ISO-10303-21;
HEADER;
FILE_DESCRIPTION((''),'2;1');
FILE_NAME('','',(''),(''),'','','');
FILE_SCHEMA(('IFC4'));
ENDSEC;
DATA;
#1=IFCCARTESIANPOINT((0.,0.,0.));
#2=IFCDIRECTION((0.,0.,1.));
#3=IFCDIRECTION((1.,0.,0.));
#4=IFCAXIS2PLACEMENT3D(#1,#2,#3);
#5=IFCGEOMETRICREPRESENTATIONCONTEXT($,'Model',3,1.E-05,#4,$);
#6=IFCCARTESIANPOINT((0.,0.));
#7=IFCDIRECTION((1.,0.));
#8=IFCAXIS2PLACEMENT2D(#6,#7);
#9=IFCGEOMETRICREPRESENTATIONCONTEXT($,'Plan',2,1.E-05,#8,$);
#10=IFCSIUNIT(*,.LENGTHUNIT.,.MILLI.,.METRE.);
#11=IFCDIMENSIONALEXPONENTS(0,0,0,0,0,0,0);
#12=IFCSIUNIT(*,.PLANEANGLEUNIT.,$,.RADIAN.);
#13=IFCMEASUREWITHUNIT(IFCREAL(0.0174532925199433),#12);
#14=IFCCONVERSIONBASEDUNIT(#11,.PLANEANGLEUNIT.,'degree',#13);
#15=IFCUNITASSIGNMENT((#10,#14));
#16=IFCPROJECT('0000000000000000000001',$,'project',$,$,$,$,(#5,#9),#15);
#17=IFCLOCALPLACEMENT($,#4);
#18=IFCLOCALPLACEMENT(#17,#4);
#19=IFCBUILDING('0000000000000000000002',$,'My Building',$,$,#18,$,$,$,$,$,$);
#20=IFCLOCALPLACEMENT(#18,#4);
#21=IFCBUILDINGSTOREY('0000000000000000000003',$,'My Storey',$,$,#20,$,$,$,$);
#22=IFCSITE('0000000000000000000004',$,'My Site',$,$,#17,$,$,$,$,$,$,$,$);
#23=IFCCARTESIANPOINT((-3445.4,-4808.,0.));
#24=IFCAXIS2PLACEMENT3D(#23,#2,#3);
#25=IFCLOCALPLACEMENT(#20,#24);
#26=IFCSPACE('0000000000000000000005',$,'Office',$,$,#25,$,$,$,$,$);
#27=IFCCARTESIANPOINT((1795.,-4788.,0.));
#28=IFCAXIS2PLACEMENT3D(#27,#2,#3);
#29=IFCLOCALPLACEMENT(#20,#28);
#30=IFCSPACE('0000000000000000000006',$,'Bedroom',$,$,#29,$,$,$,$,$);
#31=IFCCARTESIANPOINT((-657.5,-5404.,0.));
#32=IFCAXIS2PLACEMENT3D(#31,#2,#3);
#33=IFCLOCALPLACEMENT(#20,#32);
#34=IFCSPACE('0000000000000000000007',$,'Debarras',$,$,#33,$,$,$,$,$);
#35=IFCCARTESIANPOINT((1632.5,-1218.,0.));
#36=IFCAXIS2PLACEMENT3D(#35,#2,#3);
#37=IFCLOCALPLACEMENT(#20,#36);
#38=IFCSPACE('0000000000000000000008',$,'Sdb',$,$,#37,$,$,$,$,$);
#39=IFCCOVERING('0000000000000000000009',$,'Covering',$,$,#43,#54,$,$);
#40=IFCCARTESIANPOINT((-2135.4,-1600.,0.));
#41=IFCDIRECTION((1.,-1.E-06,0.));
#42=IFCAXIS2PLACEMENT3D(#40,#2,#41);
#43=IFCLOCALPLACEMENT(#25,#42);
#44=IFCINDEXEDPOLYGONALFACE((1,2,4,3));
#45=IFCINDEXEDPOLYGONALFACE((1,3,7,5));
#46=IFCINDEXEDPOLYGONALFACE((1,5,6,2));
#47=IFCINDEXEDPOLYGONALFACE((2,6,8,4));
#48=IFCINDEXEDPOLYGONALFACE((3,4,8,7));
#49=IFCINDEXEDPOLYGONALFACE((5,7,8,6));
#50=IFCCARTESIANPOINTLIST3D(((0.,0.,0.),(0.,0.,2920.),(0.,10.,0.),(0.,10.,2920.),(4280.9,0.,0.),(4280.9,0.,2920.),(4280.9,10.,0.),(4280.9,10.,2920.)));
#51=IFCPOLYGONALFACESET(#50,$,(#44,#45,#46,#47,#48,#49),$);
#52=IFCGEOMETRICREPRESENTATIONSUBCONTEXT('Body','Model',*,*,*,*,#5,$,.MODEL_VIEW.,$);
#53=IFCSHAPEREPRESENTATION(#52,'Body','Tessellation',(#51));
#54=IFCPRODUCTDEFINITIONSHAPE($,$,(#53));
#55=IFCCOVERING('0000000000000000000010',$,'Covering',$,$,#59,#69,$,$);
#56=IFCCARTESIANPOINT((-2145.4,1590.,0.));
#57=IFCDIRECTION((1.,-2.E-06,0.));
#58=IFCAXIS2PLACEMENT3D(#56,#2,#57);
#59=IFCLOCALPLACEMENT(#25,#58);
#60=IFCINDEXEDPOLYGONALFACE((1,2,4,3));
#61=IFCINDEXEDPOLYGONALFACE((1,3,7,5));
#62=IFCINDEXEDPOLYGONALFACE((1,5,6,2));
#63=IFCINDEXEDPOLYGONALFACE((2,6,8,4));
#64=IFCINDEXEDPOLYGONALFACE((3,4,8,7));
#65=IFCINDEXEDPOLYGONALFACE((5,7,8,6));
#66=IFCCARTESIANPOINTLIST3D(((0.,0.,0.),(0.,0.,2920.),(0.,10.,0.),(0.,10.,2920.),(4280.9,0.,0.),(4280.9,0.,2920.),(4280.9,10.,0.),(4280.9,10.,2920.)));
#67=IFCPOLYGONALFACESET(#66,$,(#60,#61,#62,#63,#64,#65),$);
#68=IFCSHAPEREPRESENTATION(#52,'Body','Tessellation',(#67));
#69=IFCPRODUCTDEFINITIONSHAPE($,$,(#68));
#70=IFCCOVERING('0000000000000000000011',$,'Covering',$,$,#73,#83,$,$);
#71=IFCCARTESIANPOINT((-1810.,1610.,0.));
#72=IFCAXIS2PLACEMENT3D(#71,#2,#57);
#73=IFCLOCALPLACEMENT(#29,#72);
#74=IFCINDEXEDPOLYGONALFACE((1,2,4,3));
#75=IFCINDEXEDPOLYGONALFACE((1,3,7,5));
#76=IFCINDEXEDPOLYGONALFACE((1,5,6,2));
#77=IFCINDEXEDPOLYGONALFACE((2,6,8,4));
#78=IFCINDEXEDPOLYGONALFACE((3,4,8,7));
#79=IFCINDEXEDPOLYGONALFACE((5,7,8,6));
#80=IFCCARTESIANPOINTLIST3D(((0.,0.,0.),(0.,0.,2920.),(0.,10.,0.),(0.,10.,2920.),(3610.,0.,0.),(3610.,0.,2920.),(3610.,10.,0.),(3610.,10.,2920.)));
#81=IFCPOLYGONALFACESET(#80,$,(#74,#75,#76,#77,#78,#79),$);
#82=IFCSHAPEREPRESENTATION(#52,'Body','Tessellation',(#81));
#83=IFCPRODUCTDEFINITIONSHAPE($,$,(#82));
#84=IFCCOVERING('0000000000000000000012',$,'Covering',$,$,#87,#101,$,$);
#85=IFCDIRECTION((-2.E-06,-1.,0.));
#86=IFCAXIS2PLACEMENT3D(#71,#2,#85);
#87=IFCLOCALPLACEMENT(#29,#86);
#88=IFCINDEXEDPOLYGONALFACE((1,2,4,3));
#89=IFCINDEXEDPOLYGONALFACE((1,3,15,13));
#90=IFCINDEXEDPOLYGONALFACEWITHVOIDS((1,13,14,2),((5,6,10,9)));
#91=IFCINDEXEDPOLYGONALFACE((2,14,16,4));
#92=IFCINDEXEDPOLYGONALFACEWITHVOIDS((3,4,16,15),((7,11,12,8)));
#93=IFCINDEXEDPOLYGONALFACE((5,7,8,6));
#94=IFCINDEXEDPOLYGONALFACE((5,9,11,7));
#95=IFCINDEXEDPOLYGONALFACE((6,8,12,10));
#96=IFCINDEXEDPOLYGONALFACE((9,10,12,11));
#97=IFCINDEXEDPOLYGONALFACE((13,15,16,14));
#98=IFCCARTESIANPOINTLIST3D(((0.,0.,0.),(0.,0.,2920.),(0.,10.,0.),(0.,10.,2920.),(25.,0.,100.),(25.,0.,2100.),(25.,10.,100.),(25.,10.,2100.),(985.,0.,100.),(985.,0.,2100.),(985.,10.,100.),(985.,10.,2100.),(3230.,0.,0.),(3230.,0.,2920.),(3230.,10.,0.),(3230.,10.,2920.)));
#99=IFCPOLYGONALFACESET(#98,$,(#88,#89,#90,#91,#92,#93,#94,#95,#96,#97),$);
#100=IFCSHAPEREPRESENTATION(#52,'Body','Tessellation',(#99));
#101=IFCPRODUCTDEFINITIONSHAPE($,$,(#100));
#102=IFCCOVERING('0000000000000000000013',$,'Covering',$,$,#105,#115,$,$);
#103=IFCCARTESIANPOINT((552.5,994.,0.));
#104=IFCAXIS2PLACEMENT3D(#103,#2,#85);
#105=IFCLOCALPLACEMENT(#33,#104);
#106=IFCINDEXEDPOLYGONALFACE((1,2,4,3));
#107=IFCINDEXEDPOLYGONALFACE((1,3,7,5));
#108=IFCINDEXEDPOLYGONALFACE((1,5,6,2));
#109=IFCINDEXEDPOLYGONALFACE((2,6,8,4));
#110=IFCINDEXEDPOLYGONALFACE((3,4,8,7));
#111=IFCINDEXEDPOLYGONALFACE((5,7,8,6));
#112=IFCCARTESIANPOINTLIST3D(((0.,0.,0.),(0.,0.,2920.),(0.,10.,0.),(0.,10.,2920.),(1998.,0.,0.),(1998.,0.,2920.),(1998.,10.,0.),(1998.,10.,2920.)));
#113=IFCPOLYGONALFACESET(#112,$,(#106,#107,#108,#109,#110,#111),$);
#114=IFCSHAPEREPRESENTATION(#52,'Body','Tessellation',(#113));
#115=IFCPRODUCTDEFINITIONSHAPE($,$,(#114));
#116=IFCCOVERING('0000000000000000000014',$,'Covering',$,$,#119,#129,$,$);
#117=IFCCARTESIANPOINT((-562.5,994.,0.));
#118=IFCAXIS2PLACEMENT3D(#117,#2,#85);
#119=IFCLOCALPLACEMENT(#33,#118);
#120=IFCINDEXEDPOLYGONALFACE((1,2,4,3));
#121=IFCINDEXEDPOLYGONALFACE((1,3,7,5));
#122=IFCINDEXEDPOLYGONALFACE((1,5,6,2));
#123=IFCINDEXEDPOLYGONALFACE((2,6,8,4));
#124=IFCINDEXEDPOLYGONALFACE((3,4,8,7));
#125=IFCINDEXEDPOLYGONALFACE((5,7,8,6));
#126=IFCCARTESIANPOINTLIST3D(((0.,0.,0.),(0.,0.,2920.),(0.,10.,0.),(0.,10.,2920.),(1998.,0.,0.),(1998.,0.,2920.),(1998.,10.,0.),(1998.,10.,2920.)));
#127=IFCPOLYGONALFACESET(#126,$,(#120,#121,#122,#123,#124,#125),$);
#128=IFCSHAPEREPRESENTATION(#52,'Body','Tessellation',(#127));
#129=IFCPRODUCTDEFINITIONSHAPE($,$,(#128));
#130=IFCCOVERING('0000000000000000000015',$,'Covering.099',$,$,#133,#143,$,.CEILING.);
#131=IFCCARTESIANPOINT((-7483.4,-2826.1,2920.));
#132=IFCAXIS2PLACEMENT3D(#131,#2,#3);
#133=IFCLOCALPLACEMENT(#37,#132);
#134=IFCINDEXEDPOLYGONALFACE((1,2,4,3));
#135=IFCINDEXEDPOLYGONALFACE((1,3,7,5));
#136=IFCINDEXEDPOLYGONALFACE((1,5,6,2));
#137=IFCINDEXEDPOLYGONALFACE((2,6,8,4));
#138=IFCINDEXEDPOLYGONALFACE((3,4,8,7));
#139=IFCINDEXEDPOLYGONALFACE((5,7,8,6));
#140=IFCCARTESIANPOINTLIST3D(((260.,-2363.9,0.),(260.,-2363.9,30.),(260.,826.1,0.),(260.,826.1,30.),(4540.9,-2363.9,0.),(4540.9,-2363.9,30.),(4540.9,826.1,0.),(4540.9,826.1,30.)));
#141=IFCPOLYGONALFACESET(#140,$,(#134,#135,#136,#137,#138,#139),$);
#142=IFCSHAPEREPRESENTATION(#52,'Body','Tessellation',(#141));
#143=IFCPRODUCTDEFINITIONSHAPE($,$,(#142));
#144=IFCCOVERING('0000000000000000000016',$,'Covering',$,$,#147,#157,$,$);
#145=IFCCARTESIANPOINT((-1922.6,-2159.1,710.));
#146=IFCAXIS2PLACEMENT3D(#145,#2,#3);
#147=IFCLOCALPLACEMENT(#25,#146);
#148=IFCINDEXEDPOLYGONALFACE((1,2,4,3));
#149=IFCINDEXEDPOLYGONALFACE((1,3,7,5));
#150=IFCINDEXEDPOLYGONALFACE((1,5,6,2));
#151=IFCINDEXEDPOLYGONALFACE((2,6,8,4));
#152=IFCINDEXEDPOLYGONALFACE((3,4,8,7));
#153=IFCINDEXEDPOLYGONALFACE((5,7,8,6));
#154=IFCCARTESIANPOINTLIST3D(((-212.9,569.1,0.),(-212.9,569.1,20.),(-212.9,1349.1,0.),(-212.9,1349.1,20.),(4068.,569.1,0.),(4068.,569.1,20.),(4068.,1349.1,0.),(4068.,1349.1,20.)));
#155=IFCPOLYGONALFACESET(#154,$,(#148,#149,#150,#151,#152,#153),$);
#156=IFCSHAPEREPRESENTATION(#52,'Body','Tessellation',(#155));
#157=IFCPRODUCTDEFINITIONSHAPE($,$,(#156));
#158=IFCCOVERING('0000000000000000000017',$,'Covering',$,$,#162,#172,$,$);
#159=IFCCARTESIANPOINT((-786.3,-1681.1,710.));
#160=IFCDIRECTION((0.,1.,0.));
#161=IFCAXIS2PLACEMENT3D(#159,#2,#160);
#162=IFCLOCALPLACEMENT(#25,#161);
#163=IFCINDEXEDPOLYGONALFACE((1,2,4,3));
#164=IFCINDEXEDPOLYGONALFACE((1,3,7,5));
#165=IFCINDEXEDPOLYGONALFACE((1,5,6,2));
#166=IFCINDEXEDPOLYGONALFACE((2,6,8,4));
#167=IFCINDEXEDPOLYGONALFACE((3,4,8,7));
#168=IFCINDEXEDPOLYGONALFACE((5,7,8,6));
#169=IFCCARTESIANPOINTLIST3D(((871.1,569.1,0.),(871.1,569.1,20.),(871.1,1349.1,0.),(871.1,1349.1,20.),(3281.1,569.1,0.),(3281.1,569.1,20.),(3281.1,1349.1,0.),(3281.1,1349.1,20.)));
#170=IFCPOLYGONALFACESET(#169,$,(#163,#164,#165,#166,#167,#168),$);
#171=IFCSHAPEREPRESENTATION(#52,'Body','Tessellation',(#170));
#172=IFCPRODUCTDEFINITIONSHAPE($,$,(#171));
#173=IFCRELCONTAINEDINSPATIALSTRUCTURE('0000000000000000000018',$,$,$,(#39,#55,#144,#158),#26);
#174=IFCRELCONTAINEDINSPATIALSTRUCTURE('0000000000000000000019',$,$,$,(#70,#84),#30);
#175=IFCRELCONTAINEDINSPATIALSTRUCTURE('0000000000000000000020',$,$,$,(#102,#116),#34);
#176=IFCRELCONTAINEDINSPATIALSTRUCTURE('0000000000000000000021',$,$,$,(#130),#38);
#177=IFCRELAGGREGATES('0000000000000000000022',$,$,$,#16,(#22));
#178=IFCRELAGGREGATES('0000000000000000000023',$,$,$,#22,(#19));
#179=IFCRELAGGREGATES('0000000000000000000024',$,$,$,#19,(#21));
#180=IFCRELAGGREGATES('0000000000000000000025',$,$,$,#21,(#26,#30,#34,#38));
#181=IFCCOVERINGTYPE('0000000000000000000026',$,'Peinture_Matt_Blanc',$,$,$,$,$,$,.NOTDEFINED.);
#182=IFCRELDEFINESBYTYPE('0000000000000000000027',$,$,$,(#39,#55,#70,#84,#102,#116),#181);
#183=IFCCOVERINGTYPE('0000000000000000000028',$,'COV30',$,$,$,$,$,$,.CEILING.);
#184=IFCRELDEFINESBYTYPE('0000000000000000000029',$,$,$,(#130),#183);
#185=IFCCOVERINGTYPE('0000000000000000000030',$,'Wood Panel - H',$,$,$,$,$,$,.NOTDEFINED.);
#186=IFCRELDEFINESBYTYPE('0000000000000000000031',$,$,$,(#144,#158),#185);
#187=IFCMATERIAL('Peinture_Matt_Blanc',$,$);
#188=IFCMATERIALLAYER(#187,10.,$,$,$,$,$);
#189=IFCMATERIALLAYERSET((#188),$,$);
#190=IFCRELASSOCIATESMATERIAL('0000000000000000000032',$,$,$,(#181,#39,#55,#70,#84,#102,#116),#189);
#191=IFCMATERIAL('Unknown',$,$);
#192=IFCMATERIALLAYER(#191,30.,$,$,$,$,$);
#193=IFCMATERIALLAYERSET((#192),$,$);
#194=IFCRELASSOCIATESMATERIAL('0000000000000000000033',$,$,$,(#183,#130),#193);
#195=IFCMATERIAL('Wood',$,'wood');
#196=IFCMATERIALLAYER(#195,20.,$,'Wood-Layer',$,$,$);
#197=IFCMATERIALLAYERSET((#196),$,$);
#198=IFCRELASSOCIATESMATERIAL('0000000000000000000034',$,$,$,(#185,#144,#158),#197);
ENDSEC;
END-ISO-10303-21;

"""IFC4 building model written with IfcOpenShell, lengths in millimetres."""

from ifc_helpers import new_model, entity, si_unit, converted_unit, frame, origin_with_axes, origin_2d_with_axis, place, context, subcontext, project, spatial, line, indexed_curve, outline, extrude, clip, halfspace, source, transform, mapped, material, layer, layer_set, layer_usage, type_object, element, save


model = new_model("IFC4")

# Units and contexts
model_context = context("Model", 3, precision=1e-05, world=origin_with_axes())
plan_context = context("Plan", 2, precision=1e-05, world=origin_2d_with_axis())
body_context_1 = subcontext(model_context, "Body", "Model", "MODEL_VIEW")
ifc_project = project(units=[si_unit("LENGTHUNIT", "METRE", prefix="MILLI"), converted_unit("PLANEANGLEUNIT", "degree", entity("IfcReal", 0.0174532925199433), si_unit("PLANEANGLEUNIT", "RADIAN"), dimensions=[0, 0, 0, 0, 0, 0, 0])], contexts=[model_context, plan_context])

# Site, building, storey
site_placement = place(None, origin_with_axes())
site = spatial("IfcSite", under=ifc_project, at=site_placement, Name="My Site")
building_placement = place(site_placement, origin_with_axes())
building = spatial("IfcBuilding", under=site, at=building_placement, Name="My Building")
storey_placement = place(building_placement, origin_with_axes())
storey = spatial("IfcBuildingStorey", under=building, at=storey_placement, Name="My Storey")

# Shared definitions
shared_shape_1 = source(origin_with_axes(), body_context_1, "Body", "SweptSolid", [
    extrude(outline(indexed_curve([(0.0, 0.0), (960.0, 0.0), (960.0, 2000.0), (0.0, 2000.0)], segments=[line(1, 2, 3, 4, 1)])), frame((0.0, -100.0, 0.0), z_axis=(0.0, -1.0, 0.0), x_axis=(1.0, 0.0, 0.0)), (0.0, 0.0, -1.0), 280.0),
])

# Shared definitions
ifc_material_1 = material(Name="Unknown")

# Shared definitions
space_1_placement = place(storey_placement, frame((-3445.4, -4808.0, 0.0), z_axis=(0.0, 0.0, 1.0), x_axis=(1.0, 0.0, 0.0)))
space_1 = spatial("IfcSpace", under=storey, at=space_1_placement, Name="Office")

# Covering
ifc_material_2 = material(Name="Peinture_Matt_Blanc")
ifc_layer_1 = layer(ifc_material_2, 10.0)
ifc_layer_set_1 = layer_set([ifc_layer_1])
ifc_layer_usage_1 = layer_usage(ifc_layer_set_1, "AXIS2", "POSITIVE", 0.0)
covering_type_1 = type_object("IfcCoveringType", Name="Peinture_Matt_Blanc", PredefinedType="NOTDEFINED", material=ifc_layer_set_1)
covering_1_placement = place(space_1_placement, frame((-2135.4, -1600.0, 0.0), z_axis=(0.0, 0.0, 1.0), x_axis=(1.0, -0.000001, 0.0)))
element("IfcCovering", 1, at=covering_1_placement, inside=space_1, type_object=covering_type_1, material=ifc_layer_usage_1, Name="Covering", context=body_context_1, shape_type="Clipping", body=[
    clip(clip(extrude(outline(indexed_curve([(0.0, 0.0), (0.0, 10.0), (4280.9, 10.0), (4280.9, 0.0), (0.0, 0.0)], self_intersect=False)), origin_with_axes(), (0.0, 0.0, 1.0), 2920.0), halfspace(frame((0.0, 0.0, 2920.0), z_axis=(0.0, 0.0, 1.0), x_axis=(-1.0, 0.0, 0.0)), False)), halfspace(frame((0.0, 0.0, 2920.0), z_axis=(0.0, 0.0, 1.0), x_axis=(-1.0, 0.0, 0.0)), False)),
])

# Covering
ifc_layer_usage_2 = layer_usage(ifc_layer_set_1, "AXIS2", "POSITIVE", 0.0)
covering_2_placement = place(space_1_placement, frame((-2145.4, 1590.0, 0.0), z_axis=(0.0, 0.0, 1.0), x_axis=(1.0, -0.000002, 0.0)))
element("IfcCovering", 2, at=covering_2_placement, inside=space_1, type_object=covering_type_1, material=ifc_layer_usage_2, Name="Covering", context=body_context_1, shape_type="Clipping", body=[
    clip(clip(extrude(outline(indexed_curve([(0.0, 0.0), (0.0, 10.0), (4280.9, 10.0), (4280.9, 0.0), (0.0, 0.0)], self_intersect=False)), origin_with_axes(), (0.0, 0.0, 1.0), 2920.0), halfspace(frame((0.0, 0.0, 2920.0), z_axis=(0.0, 0.0, 1.0), x_axis=(-1.0, 0.0, 0.0)), False)), halfspace(frame((0.0, 0.0, 2920.0), z_axis=(0.0, 0.0, 1.0), x_axis=(-1.0, 0.0, 0.0)), False)),
])

# Shared definitions
space_2_placement = place(storey_placement, frame((1795.0, -4788.0, 0.0), z_axis=(0.0, 0.0, 1.0), x_axis=(1.0, 0.0, 0.0)))
space_2 = spatial("IfcSpace", under=storey, at=space_2_placement, Name="Bedroom")

# Covering
ifc_layer_usage_3 = layer_usage(ifc_layer_set_1, "AXIS2", "POSITIVE", 0.0)
covering_3_placement = place(space_2_placement, frame((-1810.0, 1610.0, 0.0), z_axis=(0.0, 0.0, 1.0), x_axis=(1.0, -0.000002, 0.0)))
element("IfcCovering", 3, at=covering_3_placement, inside=space_2, type_object=covering_type_1, material=ifc_layer_usage_3, Name="Covering", context=body_context_1, shape_type="Clipping", body=[
    clip(clip(extrude(outline(indexed_curve([(0.0, 0.0), (0.0, 10.0), (3610.0, 10.0), (3610.0, 0.0), (0.0, 0.0)], self_intersect=False)), origin_with_axes(), (0.0, 0.0, 1.0), 2920.0), halfspace(frame((0.0, 0.0, 2920.0), z_axis=(0.0, 0.0, 1.0), x_axis=(-1.0, 0.0, 0.0)), False)), halfspace(frame((0.0, 0.0, 2920.0), z_axis=(0.0, 0.0, 1.0), x_axis=(-1.0, 0.0, 0.0)), False)),
])

# Covering, opening
ifc_layer_usage_4 = layer_usage(ifc_layer_set_1, "AXIS2", "POSITIVE", 0.0)
covering_4_placement = place(space_2_placement, frame((-1810.0, 1610.0, 0.0), z_axis=(0.0, 0.0, 1.0), x_axis=(-0.000002, -1.0, 0.0)))
covering_4 = element("IfcCovering", 4, at=covering_4_placement, inside=space_2, type_object=covering_type_1, material=ifc_layer_usage_4, Name="Covering", context=body_context_1, shape_type="Clipping", body=[
    clip(clip(extrude(outline(indexed_curve([(0.0, 0.0), (0.0, 10.0), (3230.0, 10.0), (3230.0, 0.0), (0.0, 0.0)], self_intersect=False)), origin_with_axes(), (0.0, 0.0, 1.0), 2920.0), halfspace(frame((0.0, 0.0, 2920.0), z_axis=(0.0, 0.0, 1.0), x_axis=(-1.0, 0.0, 0.0)), False)), halfspace(frame((0.0, 0.0, 2920.0), z_axis=(0.0, 0.0, 1.0), x_axis=(-1.0, 0.0, 0.0)), False)),
])
opening_1_placement = place(covering_4_placement, frame((25.0, -82.5, 100.0), z_axis=(0.0, 0.0, 1.0), x_axis=(1.0, 0.000002, 0.0)))
element("IfcOpeningElement", 5, at=opening_1_placement, cuts=covering_4, PredefinedType="OPENING", context=body_context_1, shape_type="MappedRepresentation", body=[
    mapped(shared_shape_1, transform((0.0, 0.0, 0.0), x_axis=(1.0, 0.0, 0.0), y_axis=(0.0, 1.0, 0.0), z_axis=(0.0, 0.0, 1.0), scale=1.0)),
])

# Shared definitions
space_3_placement = place(storey_placement, frame((-657.5, -5404.0, 0.0), z_axis=(0.0, 0.0, 1.0), x_axis=(1.0, 0.0, 0.0)))
space_3 = spatial("IfcSpace", under=storey, at=space_3_placement, Name="Debarras")

# Coverings
ifc_layer_usage_5 = layer_usage(ifc_layer_set_1, "AXIS2", "POSITIVE", 0.0)
covering_5_placement = place(space_3_placement, frame((552.5, 994.0, 0.0), z_axis=(0.0, 0.0, 1.0), x_axis=(-0.000002, -1.0, 0.0)))
element("IfcCovering", 6, at=covering_5_placement, inside=space_3, type_object=covering_type_1, material=ifc_layer_usage_5, Name="Covering", context=body_context_1, shape_type="Clipping", body=[
    clip(clip(extrude(outline(indexed_curve([(0.0, 0.0), (0.0, 10.0), (1998.0, 10.0), (1998.0, 0.0), (0.0, 0.0)], self_intersect=False)), origin_with_axes(), (0.0, 0.0, 1.0), 2920.0), halfspace(frame((0.0, 0.0, 2920.0), z_axis=(0.0, 0.0, 1.0), x_axis=(-1.0, 0.0, 0.0)), False)), halfspace(frame((0.0, 0.0, 2920.0), z_axis=(0.0, 0.0, 1.0), x_axis=(-1.0, 0.0, 0.0)), False)),
])
ifc_layer_usage_6 = layer_usage(ifc_layer_set_1, "AXIS2", "POSITIVE", 0.0)
covering_6_placement = place(space_3_placement, frame((-562.5, 994.0, 0.0), z_axis=(0.0, 0.0, 1.0), x_axis=(-0.000002, -1.0, 0.0)))
element("IfcCovering", 7, at=covering_6_placement, inside=space_3, type_object=covering_type_1, material=ifc_layer_usage_6, Name="Covering", context=body_context_1, shape_type="Clipping", body=[
    clip(clip(extrude(outline(indexed_curve([(0.0, 0.0), (0.0, 10.0), (1998.0, 10.0), (1998.0, 0.0), (0.0, 0.0)], self_intersect=False)), origin_with_axes(), (0.0, 0.0, 1.0), 2920.0), halfspace(frame((0.0, 0.0, 2920.0), z_axis=(0.0, 0.0, 1.0), x_axis=(-1.0, 0.0, 0.0)), False)), halfspace(frame((0.0, 0.0, 2920.0), z_axis=(0.0, 0.0, 1.0), x_axis=(-1.0, 0.0, 0.0)), False)),
])

# Shared definitions
space_4_placement = place(storey_placement, frame((1632.5, -1218.0, 0.0), z_axis=(0.0, 0.0, 1.0), x_axis=(1.0, 0.0, 0.0)))
space_4 = spatial("IfcSpace", under=storey, at=space_4_placement, Name="Sdb")

# Coverings
ifc_layer_2 = layer(ifc_material_1, 30.0)
ifc_layer_set_2 = layer_set([ifc_layer_2])
ifc_layer_usage_7 = layer_usage(ifc_layer_set_2, "AXIS3", "POSITIVE", 0.0)
covering_type_2 = type_object("IfcCoveringType", Name="COV30", PredefinedType="CEILING", material=ifc_layer_set_2)
covering_7_placement = place(space_4_placement, frame((-7483.4, -2826.1, 2920.0), z_axis=(0.0, 0.0, 1.0), x_axis=(1.0, 0.0, 0.0)))
element("IfcCovering", 8, at=covering_7_placement, inside=space_4, type_object=covering_type_2, material=ifc_layer_usage_7, Name="Covering.099", PredefinedType="CEILING", context=body_context_1, shape_type="SolidModel", body=[
    extrude(outline(indexed_curve([(4540.9, 826.1), (4540.9, -2363.9), (260.0, -2363.9), (260.0, 826.1), (4540.9, 826.1)])), None, (0.0, 0.0, 1.0), 30.0),
])
ifc_material_3 = material(Name="Wood", Category="wood")
ifc_layer_3 = layer(ifc_material_3, 20.0, Name="Wood-Layer")
ifc_layer_set_3 = layer_set([ifc_layer_3])
ifc_layer_usage_8 = layer_usage(ifc_layer_set_3, "AXIS3", "POSITIVE", 0.0)
covering_type_3 = type_object("IfcCoveringType", Name="Wood Panel - H", PredefinedType="NOTDEFINED", material=ifc_layer_set_3)
covering_8_placement = place(space_1_placement, frame((-1922.6, -2159.1, 710.0), z_axis=(0.0, 0.0, 1.0), x_axis=(1.0, 0.0, 0.0)))
element("IfcCovering", 9, at=covering_8_placement, inside=space_1, type_object=covering_type_3, material=ifc_layer_usage_8, Name="Covering", context=body_context_1, shape_type="SweptSolid", body=[
    extrude(outline(indexed_curve([(4068.0, 1349.1), (4068.0, 569.1), (-212.9, 569.1), (-212.9, 1349.1)], segments=[line(4, 1), line(1, 2), line(2, 3), line(3, 4)], self_intersect=False)), None, (0.0, 0.0, 1.0), 20.0),
])
ifc_layer_usage_9 = layer_usage(ifc_layer_set_3, "AXIS3", "POSITIVE", 0.0)
covering_9_placement = place(space_1_placement, frame((-786.3, -1681.1, 710.0), z_axis=(0.0, 0.0, 1.0), x_axis=(0.0, 1.0, 0.0)))
element("IfcCovering", 10, at=covering_9_placement, inside=space_1, type_object=covering_type_3, material=ifc_layer_usage_9, Name="Covering", context=body_context_1, shape_type="SweptSolid", body=[
    extrude(outline(indexed_curve([(871.1, 1349.1), (3281.1, 1349.1), (3281.1, 569.1), (871.1, 569.1)], segments=[line(3, 2), line(2, 1), line(1, 4), line(4, 3)], self_intersect=False)), None, (0.0, 0.0, 1.0), 20.0),
])

save(model, "model.ifc")
